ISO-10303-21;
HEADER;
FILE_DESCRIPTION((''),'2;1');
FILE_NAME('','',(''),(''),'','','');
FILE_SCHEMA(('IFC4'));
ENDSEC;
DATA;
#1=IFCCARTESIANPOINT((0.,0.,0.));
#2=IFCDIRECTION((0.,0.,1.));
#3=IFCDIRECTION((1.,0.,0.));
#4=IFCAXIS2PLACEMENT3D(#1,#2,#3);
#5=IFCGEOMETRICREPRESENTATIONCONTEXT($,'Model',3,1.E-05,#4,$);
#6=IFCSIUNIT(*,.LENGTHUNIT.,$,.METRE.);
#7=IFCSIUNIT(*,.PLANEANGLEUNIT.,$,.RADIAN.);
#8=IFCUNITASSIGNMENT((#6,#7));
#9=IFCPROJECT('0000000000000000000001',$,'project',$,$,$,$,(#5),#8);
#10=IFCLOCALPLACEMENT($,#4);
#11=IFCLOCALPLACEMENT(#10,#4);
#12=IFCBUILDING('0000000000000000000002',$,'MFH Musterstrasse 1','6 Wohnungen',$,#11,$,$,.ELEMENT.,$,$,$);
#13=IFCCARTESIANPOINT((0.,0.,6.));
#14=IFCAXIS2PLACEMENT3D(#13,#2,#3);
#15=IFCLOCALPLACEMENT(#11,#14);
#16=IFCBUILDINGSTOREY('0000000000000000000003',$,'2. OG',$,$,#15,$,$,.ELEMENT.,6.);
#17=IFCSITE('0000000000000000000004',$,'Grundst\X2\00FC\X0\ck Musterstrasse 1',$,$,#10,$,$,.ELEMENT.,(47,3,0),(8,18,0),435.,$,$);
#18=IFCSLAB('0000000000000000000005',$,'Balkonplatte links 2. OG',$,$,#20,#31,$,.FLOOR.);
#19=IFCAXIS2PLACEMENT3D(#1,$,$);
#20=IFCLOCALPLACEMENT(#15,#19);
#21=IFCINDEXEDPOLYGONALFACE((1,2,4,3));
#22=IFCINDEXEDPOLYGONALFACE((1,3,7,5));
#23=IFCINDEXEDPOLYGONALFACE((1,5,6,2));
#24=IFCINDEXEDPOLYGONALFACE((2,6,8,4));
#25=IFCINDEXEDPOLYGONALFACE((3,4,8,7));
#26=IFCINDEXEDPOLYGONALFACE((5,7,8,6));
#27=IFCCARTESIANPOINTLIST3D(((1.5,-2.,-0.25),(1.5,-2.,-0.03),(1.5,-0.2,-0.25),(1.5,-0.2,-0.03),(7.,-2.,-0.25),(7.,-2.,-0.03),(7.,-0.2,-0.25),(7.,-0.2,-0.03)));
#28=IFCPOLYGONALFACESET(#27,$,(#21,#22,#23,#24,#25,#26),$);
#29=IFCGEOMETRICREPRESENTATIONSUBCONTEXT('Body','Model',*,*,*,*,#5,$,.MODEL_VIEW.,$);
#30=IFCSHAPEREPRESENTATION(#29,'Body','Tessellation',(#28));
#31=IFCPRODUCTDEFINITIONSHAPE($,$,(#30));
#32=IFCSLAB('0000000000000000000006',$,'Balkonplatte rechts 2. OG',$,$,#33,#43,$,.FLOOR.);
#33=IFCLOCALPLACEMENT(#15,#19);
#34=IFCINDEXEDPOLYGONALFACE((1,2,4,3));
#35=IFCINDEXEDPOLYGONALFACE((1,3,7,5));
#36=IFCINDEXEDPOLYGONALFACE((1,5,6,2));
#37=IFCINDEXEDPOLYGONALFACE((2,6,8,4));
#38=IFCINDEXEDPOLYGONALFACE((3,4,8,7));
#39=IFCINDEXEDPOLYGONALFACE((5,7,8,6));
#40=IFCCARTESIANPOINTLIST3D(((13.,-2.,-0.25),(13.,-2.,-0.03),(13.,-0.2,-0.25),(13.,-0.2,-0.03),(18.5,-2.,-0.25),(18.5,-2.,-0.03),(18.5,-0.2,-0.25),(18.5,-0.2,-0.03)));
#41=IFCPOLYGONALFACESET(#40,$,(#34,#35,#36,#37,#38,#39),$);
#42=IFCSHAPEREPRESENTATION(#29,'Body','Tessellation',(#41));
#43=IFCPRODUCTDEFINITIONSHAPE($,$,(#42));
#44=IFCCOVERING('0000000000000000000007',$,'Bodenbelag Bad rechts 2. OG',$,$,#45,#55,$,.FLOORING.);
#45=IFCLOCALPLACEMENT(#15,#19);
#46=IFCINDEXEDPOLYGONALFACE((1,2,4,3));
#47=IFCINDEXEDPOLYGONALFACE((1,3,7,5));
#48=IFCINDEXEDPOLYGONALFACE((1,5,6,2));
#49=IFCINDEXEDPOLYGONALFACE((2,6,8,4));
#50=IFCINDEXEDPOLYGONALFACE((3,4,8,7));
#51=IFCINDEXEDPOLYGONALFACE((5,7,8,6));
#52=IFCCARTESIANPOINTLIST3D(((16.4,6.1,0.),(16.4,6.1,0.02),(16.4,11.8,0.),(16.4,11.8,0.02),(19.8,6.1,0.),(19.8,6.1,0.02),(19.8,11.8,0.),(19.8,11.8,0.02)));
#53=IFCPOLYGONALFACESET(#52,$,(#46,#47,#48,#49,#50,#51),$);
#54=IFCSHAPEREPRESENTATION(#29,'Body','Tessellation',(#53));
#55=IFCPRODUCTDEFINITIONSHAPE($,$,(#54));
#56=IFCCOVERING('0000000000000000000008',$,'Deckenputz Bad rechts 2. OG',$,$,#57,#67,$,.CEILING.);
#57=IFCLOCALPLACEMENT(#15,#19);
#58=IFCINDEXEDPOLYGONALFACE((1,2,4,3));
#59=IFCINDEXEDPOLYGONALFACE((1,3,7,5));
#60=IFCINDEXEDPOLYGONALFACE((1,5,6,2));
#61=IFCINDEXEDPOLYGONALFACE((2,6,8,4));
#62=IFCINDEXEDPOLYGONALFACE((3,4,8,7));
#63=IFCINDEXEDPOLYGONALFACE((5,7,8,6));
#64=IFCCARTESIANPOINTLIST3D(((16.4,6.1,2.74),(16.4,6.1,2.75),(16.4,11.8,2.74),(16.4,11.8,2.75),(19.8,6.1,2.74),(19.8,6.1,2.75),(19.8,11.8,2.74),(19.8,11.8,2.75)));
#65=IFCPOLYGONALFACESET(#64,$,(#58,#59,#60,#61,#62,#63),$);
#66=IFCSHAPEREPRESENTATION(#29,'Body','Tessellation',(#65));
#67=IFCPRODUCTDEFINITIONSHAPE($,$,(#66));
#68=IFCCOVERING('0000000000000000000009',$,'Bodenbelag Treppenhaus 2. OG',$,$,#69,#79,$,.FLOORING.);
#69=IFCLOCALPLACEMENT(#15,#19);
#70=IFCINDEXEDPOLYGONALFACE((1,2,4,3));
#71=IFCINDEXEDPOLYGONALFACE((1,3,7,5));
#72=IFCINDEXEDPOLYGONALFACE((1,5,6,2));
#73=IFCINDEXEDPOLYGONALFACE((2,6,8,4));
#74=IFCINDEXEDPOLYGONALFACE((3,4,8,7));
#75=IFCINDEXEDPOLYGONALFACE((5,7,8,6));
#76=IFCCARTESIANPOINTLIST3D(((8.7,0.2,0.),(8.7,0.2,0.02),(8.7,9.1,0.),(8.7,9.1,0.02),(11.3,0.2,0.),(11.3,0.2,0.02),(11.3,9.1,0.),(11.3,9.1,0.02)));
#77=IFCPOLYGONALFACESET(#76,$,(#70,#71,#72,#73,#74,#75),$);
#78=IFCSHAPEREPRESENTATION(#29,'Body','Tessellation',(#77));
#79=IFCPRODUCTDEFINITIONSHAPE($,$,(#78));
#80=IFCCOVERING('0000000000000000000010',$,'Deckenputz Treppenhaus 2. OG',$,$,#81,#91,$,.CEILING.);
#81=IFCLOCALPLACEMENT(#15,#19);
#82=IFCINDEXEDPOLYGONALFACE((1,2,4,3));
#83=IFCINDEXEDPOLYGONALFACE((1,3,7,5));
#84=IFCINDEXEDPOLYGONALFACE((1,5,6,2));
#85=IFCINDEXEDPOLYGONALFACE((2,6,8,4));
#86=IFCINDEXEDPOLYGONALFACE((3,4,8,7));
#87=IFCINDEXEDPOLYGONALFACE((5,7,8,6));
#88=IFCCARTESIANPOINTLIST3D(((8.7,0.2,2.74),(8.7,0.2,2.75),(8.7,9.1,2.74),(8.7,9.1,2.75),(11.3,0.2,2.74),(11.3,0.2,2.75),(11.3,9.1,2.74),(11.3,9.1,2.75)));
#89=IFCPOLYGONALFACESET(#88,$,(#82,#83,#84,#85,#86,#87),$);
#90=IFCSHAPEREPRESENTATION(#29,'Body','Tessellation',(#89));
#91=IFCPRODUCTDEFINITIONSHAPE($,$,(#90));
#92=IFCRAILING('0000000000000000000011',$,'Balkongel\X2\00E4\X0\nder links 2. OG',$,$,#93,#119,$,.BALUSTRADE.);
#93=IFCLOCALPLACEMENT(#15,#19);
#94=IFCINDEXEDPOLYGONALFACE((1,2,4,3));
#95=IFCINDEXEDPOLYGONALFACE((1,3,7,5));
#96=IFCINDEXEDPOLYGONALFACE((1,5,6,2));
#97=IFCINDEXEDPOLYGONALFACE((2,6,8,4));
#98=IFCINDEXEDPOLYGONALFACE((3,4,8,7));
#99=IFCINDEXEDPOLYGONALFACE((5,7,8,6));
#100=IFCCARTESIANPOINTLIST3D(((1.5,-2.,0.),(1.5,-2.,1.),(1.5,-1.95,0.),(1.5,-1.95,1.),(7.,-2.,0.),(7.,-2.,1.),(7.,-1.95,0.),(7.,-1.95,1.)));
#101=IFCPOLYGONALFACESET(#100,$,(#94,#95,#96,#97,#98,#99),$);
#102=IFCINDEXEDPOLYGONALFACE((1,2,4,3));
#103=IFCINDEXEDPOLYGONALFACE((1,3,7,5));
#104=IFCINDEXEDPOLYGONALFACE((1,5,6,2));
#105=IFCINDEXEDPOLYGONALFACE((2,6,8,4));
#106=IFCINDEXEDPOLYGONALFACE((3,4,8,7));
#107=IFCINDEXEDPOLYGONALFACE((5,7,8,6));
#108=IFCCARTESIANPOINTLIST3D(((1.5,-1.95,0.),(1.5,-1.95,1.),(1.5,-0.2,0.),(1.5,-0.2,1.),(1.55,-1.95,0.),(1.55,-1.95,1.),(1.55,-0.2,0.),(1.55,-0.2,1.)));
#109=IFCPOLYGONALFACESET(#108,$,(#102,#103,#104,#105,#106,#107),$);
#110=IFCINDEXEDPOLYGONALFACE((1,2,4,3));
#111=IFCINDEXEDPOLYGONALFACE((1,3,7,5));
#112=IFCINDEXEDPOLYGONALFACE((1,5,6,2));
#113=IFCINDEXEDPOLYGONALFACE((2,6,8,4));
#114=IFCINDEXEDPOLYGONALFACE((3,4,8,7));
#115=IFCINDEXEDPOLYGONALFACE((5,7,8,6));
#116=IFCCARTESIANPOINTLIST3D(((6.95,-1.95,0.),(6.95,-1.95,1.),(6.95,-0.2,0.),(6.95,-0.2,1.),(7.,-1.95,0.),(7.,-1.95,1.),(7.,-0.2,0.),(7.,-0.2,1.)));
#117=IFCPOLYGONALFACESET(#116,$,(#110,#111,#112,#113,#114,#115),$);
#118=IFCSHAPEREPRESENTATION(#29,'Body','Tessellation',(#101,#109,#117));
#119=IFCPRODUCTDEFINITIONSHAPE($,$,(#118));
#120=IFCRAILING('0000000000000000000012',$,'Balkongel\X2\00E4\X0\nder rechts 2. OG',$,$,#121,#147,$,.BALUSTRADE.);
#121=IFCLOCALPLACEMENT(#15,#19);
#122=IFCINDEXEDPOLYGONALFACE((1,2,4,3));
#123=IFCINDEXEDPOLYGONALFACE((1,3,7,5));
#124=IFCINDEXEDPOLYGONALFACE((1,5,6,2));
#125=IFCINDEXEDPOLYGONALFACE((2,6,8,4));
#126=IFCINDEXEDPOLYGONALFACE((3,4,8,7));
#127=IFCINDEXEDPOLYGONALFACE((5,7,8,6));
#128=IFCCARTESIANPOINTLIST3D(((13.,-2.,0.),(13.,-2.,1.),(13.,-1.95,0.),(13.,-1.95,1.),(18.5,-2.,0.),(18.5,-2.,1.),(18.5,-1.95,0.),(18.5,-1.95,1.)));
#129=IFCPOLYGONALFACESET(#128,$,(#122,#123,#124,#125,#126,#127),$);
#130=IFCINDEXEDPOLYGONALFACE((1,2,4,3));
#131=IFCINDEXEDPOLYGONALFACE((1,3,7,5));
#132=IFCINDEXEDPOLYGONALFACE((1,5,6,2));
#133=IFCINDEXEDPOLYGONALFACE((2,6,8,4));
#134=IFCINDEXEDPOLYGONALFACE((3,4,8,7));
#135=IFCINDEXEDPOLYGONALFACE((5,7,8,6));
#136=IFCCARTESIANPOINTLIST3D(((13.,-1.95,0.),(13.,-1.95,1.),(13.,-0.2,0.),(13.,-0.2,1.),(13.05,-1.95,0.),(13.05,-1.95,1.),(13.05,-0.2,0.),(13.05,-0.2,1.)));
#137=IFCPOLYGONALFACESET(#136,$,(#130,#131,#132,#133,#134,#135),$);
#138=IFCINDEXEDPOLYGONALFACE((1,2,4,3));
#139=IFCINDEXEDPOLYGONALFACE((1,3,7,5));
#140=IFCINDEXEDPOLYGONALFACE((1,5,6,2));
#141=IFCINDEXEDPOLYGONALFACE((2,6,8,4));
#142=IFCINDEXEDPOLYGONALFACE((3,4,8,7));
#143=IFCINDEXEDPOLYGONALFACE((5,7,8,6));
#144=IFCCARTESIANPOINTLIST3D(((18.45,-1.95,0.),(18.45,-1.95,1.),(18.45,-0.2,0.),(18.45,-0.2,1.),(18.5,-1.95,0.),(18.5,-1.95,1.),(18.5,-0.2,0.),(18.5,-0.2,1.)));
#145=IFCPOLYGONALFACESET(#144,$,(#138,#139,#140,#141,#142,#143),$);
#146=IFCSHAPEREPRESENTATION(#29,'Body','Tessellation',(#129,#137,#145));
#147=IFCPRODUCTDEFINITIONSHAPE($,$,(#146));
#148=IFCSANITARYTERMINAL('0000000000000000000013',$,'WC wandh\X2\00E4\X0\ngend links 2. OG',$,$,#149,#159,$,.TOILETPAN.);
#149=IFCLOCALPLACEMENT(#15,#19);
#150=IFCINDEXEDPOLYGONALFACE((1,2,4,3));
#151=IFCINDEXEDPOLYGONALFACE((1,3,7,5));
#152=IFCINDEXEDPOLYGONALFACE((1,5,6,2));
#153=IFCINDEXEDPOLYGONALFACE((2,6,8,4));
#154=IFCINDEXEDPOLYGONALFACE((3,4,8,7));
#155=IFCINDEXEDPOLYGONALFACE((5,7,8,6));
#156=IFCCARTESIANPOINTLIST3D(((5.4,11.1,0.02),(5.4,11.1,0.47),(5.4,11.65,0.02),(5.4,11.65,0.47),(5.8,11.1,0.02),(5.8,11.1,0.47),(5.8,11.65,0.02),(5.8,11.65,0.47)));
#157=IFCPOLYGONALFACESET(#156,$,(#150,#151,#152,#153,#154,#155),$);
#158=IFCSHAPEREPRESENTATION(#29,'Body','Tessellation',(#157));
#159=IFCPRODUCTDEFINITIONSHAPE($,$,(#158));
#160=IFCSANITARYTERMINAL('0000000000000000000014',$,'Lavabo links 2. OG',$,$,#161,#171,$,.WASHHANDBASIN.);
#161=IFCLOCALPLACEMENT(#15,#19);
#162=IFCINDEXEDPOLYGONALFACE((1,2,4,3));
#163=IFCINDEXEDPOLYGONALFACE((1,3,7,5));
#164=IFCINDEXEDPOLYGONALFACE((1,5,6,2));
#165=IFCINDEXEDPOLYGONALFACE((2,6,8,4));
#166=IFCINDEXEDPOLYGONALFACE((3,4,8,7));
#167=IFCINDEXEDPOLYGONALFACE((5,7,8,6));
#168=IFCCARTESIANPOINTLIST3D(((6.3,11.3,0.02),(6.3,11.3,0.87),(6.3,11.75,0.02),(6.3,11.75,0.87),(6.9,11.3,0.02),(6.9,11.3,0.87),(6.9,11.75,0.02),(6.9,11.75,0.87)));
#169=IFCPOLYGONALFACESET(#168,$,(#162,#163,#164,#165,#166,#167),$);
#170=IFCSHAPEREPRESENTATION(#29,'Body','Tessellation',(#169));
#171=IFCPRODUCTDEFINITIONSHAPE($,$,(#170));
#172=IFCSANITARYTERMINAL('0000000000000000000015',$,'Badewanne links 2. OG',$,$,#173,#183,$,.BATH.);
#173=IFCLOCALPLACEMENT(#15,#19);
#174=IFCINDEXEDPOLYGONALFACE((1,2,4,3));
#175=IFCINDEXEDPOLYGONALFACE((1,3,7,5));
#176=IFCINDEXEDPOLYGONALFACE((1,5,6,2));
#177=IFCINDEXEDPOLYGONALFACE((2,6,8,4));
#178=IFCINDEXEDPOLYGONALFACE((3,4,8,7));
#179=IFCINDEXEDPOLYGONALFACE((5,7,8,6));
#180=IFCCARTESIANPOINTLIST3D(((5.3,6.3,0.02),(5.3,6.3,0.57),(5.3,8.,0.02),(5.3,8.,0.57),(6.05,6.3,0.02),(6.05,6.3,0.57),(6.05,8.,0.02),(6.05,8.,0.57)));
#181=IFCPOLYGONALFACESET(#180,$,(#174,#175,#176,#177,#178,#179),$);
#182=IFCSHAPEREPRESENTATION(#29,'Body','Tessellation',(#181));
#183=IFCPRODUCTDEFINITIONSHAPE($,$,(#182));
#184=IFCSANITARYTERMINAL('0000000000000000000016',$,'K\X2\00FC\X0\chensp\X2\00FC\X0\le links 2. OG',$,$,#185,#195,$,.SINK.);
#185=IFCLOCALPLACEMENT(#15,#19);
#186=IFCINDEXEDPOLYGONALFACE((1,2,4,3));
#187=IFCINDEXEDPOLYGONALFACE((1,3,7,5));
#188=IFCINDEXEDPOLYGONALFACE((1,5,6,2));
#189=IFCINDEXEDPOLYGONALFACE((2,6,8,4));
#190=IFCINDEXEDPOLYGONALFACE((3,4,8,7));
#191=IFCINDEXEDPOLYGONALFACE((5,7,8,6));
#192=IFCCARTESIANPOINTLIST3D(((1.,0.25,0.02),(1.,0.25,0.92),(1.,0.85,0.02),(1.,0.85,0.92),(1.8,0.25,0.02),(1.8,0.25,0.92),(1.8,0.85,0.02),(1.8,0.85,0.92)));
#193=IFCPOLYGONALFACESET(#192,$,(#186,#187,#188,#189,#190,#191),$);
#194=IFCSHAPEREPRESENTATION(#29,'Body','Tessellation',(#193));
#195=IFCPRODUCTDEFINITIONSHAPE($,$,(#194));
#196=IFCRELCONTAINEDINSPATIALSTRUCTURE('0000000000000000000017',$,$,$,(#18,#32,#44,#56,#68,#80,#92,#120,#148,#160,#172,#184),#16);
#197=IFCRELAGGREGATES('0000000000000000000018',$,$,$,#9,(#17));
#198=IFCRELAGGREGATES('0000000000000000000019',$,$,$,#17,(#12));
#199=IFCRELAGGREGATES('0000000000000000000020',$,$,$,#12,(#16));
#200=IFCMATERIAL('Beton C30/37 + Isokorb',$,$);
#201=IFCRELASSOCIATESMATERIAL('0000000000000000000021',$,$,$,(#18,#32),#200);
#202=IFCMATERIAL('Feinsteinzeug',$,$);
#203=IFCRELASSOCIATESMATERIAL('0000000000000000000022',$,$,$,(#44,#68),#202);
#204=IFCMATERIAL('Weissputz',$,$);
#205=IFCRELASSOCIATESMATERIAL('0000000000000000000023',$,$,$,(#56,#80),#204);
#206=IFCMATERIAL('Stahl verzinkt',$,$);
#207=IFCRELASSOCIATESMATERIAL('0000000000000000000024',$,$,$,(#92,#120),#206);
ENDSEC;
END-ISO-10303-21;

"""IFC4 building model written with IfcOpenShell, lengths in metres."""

from ifc_helpers import new_model, si_unit, frame, frame_2d, origin_with_axes, place, context, subcontext, project, spatial, rectangle, extrude, material, element, save


model = new_model("IFC4")

# Units and contexts
model_context = context("Model", 3, precision=1e-05, world=origin_with_axes())
body_context = subcontext(model_context, "Body", "Model", "MODEL_VIEW")
ifc_project = project(units=[si_unit("LENGTHUNIT", "METRE"), si_unit("PLANEANGLEUNIT", "RADIAN")], contexts=[model_context])

# Site, building, storey
site_placement = place(None, origin_with_axes())
site = spatial("IfcSite", under=ifc_project, at=site_placement, Name="Grundstück Musterstrasse 1", CompositionType="ELEMENT", RefLatitude=(47, 3, 0), RefLongitude=(8, 18, 0), RefElevation=435.0)
building_placement = place(site_placement, origin_with_axes())
building = spatial("IfcBuilding", under=site, at=building_placement, Name="MFH Musterstrasse 1", Description="6 Wohnungen", CompositionType="ELEMENT")
storey_placement = place(building_placement, frame((0.0, 0.0, 6.0), z_axis=(0.0, 0.0, 1.0), x_axis=(1.0, 0.0, 0.0)))
storey = spatial("IfcBuildingStorey", under=building, at=storey_placement, Name="2. OG", CompositionType="ELEMENT", Elevation=6.0)

# Slabs
ifc_material_1 = material(Name="Beton C30/37 + Isokorb")
slab_1_placement = place(storey_placement, origin_with_axes())
element("IfcSlab", 1, at=slab_1_placement, inside=storey, material=ifc_material_1, Name="Balkonplatte links 2. OG", PredefinedType="FLOOR", context=body_context, shape_type="SweptSolid", body=[
    extrude(rectangle(XDim=5.5, YDim=1.8, at=frame_2d((2.75, 0.9), x_axis=(1.0, 0.0))), frame((1.5, -2.0, -0.25), z_axis=(0.0, 0.0, 1.0), x_axis=(1.0, 0.0, 0.0)), (0.0, 0.0, 1.0), 0.22),
])
slab_2_placement = place(storey_placement, origin_with_axes())
element("IfcSlab", 2, at=slab_2_placement, inside=storey, material=ifc_material_1, Name="Balkonplatte rechts 2. OG", PredefinedType="FLOOR", context=body_context, shape_type="SweptSolid", body=[
    extrude(rectangle(XDim=5.5, YDim=1.8, at=frame_2d((2.75, 0.9), x_axis=(1.0, 0.0))), frame((13.0, -2.0, -0.25), z_axis=(0.0, 0.0, 1.0), x_axis=(1.0, 0.0, 0.0)), (0.0, 0.0, 1.0), 0.22),
])

# Coverings
ifc_material_2 = material(Name="Feinsteinzeug")
covering_1_placement = place(storey_placement, origin_with_axes())
element("IfcCovering", 3, at=covering_1_placement, inside=storey, material=ifc_material_2, Name="Bodenbelag Bad rechts 2. OG", PredefinedType="FLOORING", context=body_context, shape_type="SweptSolid", body=[
    extrude(rectangle(XDim=3.4, YDim=5.7, at=frame_2d((1.7, 2.85), x_axis=(1.0, 0.0))), frame((16.4, 6.1, 0.0), z_axis=(0.0, 0.0, 1.0), x_axis=(1.0, 0.0, 0.0)), (0.0, 0.0, 1.0), 0.02),
])
ifc_material_3 = material(Name="Weissputz")
covering_2_placement = place(storey_placement, origin_with_axes())
element("IfcCovering", 4, at=covering_2_placement, inside=storey, material=ifc_material_3, Name="Deckenputz Bad rechts 2. OG", PredefinedType="CEILING", context=body_context, shape_type="SweptSolid", body=[
    extrude(rectangle(XDim=3.4, YDim=5.7, at=frame_2d((1.7, 2.85), x_axis=(1.0, 0.0))), frame((16.4, 6.1, 2.74), z_axis=(0.0, 0.0, 1.0), x_axis=(1.0, 0.0, 0.0)), (0.0, 0.0, 1.0), 0.01),
])
covering_3_placement = place(storey_placement, origin_with_axes())
element("IfcCovering", 5, at=covering_3_placement, inside=storey, material=ifc_material_2, Name="Bodenbelag Treppenhaus 2. OG", PredefinedType="FLOORING", context=body_context, shape_type="SweptSolid", body=[
    extrude(rectangle(XDim=2.6, YDim=8.9, at=frame_2d((1.3, 4.45), x_axis=(1.0, 0.0))), frame((8.7, 0.2, 0.0), z_axis=(0.0, 0.0, 1.0), x_axis=(1.0, 0.0, 0.0)), (0.0, 0.0, 1.0), 0.02),
])
covering_4_placement = place(storey_placement, origin_with_axes())
element("IfcCovering", 6, at=covering_4_placement, inside=storey, material=ifc_material_3, Name="Deckenputz Treppenhaus 2. OG", PredefinedType="CEILING", context=body_context, shape_type="SweptSolid", body=[
    extrude(rectangle(XDim=2.6, YDim=8.9, at=frame_2d((1.3, 4.45), x_axis=(1.0, 0.0))), frame((8.7, 0.2, 2.74), z_axis=(0.0, 0.0, 1.0), x_axis=(1.0, 0.0, 0.0)), (0.0, 0.0, 1.0), 0.01),
])

# Railings
ifc_material_4 = material(Name="Stahl verzinkt")
railing_1_placement = place(storey_placement, origin_with_axes())
element("IfcRailing", 7, at=railing_1_placement, inside=storey, material=ifc_material_4, Name="Balkongeländer links 2. OG", PredefinedType="BALUSTRADE", context=body_context, shape_type="SweptSolid", body=[
    extrude(rectangle(XDim=5.5, YDim=0.05, at=frame_2d((2.75, 0.025), x_axis=(1.0, 0.0))), frame((1.5, -2.0, 0.0), z_axis=(0.0, 0.0, 1.0), x_axis=(1.0, 0.0, 0.0)), (0.0, 0.0, 1.0), 1.0),
    extrude(rectangle(XDim=0.05, YDim=1.75, at=frame_2d((0.025, 0.875), x_axis=(1.0, 0.0))), frame((1.5, -1.95, 0.0), z_axis=(0.0, 0.0, 1.0), x_axis=(1.0, 0.0, 0.0)), (0.0, 0.0, 1.0), 1.0),
    extrude(rectangle(XDim=0.05, YDim=1.75, at=frame_2d((0.025, 0.875), x_axis=(1.0, 0.0))), frame((6.95, -1.95, 0.0), z_axis=(0.0, 0.0, 1.0), x_axis=(1.0, 0.0, 0.0)), (0.0, 0.0, 1.0), 1.0),
])
railing_2_placement = place(storey_placement, origin_with_axes())
element("IfcRailing", 8, at=railing_2_placement, inside=storey, material=ifc_material_4, Name="Balkongeländer rechts 2. OG", PredefinedType="BALUSTRADE", context=body_context, shape_type="SweptSolid", body=[
    extrude(rectangle(XDim=5.5, YDim=0.05, at=frame_2d((2.75, 0.025), x_axis=(1.0, 0.0))), frame((13.0, -2.0, 0.0), z_axis=(0.0, 0.0, 1.0), x_axis=(1.0, 0.0, 0.0)), (0.0, 0.0, 1.0), 1.0),
    extrude(rectangle(XDim=0.05, YDim=1.75, at=frame_2d((0.025, 0.875), x_axis=(1.0, 0.0))), frame((13.0, -1.95, 0.0), z_axis=(0.0, 0.0, 1.0), x_axis=(1.0, 0.0, 0.0)), (0.0, 0.0, 1.0), 1.0),
    extrude(rectangle(XDim=0.05, YDim=1.75, at=frame_2d((0.025, 0.875), x_axis=(1.0, 0.0))), frame((18.45, -1.95, 0.0), z_axis=(0.0, 0.0, 1.0), x_axis=(1.0, 0.0, 0.0)), (0.0, 0.0, 1.0), 1.0),
])

# Sanitary terminals
sanitary_terminal_1_placement = place(storey_placement, origin_with_axes())
element("IfcSanitaryTerminal", 9, at=sanitary_terminal_1_placement, inside=storey, Name="WC wandhängend links 2. OG", PredefinedType="TOILETPAN", context=body_context, shape_type="SweptSolid", body=[
    extrude(rectangle(XDim=0.4, YDim=0.55, at=frame_2d((0.2, 0.275), x_axis=(1.0, 0.0))), frame((5.4, 11.1, 0.02), z_axis=(0.0, 0.0, 1.0), x_axis=(1.0, 0.0, 0.0)), (0.0, 0.0, 1.0), 0.45),
])
sanitary_terminal_2_placement = place(storey_placement, origin_with_axes())
element("IfcSanitaryTerminal", 10, at=sanitary_terminal_2_placement, inside=storey, Name="Lavabo links 2. OG", PredefinedType="WASHHANDBASIN", context=body_context, shape_type="SweptSolid", body=[
    extrude(rectangle(XDim=0.6, YDim=0.45, at=frame_2d((0.3, 0.225), x_axis=(1.0, 0.0))), frame((6.3, 11.3, 0.02), z_axis=(0.0, 0.0, 1.0), x_axis=(1.0, 0.0, 0.0)), (0.0, 0.0, 1.0), 0.85),
])
sanitary_terminal_3_placement = place(storey_placement, origin_with_axes())
element("IfcSanitaryTerminal", 11, at=sanitary_terminal_3_placement, inside=storey, Name="Badewanne links 2. OG", PredefinedType="BATH", context=body_context, shape_type="SweptSolid", body=[
    extrude(rectangle(XDim=0.75, YDim=1.7, at=frame_2d((0.375, 0.85), x_axis=(1.0, 0.0))), frame((5.3, 6.3, 0.02), z_axis=(0.0, 0.0, 1.0), x_axis=(1.0, 0.0, 0.0)), (0.0, 0.0, 1.0), 0.55),
])
sanitary_terminal_4_placement = place(storey_placement, origin_with_axes())
element("IfcSanitaryTerminal", 12, at=sanitary_terminal_4_placement, inside=storey, Name="Küchenspüle links 2. OG", PredefinedType="SINK", context=body_context, shape_type="SweptSolid", body=[
    extrude(rectangle(XDim=0.8, YDim=0.6, at=frame_2d((0.4, 0.3), x_axis=(1.0, 0.0))), frame((1.0, 0.25, 0.02), z_axis=(0.0, 0.0, 1.0), x_axis=(1.0, 0.0, 0.0)), (0.0, 0.0, 1.0), 0.9),
])

save(model, "model.ifc")
